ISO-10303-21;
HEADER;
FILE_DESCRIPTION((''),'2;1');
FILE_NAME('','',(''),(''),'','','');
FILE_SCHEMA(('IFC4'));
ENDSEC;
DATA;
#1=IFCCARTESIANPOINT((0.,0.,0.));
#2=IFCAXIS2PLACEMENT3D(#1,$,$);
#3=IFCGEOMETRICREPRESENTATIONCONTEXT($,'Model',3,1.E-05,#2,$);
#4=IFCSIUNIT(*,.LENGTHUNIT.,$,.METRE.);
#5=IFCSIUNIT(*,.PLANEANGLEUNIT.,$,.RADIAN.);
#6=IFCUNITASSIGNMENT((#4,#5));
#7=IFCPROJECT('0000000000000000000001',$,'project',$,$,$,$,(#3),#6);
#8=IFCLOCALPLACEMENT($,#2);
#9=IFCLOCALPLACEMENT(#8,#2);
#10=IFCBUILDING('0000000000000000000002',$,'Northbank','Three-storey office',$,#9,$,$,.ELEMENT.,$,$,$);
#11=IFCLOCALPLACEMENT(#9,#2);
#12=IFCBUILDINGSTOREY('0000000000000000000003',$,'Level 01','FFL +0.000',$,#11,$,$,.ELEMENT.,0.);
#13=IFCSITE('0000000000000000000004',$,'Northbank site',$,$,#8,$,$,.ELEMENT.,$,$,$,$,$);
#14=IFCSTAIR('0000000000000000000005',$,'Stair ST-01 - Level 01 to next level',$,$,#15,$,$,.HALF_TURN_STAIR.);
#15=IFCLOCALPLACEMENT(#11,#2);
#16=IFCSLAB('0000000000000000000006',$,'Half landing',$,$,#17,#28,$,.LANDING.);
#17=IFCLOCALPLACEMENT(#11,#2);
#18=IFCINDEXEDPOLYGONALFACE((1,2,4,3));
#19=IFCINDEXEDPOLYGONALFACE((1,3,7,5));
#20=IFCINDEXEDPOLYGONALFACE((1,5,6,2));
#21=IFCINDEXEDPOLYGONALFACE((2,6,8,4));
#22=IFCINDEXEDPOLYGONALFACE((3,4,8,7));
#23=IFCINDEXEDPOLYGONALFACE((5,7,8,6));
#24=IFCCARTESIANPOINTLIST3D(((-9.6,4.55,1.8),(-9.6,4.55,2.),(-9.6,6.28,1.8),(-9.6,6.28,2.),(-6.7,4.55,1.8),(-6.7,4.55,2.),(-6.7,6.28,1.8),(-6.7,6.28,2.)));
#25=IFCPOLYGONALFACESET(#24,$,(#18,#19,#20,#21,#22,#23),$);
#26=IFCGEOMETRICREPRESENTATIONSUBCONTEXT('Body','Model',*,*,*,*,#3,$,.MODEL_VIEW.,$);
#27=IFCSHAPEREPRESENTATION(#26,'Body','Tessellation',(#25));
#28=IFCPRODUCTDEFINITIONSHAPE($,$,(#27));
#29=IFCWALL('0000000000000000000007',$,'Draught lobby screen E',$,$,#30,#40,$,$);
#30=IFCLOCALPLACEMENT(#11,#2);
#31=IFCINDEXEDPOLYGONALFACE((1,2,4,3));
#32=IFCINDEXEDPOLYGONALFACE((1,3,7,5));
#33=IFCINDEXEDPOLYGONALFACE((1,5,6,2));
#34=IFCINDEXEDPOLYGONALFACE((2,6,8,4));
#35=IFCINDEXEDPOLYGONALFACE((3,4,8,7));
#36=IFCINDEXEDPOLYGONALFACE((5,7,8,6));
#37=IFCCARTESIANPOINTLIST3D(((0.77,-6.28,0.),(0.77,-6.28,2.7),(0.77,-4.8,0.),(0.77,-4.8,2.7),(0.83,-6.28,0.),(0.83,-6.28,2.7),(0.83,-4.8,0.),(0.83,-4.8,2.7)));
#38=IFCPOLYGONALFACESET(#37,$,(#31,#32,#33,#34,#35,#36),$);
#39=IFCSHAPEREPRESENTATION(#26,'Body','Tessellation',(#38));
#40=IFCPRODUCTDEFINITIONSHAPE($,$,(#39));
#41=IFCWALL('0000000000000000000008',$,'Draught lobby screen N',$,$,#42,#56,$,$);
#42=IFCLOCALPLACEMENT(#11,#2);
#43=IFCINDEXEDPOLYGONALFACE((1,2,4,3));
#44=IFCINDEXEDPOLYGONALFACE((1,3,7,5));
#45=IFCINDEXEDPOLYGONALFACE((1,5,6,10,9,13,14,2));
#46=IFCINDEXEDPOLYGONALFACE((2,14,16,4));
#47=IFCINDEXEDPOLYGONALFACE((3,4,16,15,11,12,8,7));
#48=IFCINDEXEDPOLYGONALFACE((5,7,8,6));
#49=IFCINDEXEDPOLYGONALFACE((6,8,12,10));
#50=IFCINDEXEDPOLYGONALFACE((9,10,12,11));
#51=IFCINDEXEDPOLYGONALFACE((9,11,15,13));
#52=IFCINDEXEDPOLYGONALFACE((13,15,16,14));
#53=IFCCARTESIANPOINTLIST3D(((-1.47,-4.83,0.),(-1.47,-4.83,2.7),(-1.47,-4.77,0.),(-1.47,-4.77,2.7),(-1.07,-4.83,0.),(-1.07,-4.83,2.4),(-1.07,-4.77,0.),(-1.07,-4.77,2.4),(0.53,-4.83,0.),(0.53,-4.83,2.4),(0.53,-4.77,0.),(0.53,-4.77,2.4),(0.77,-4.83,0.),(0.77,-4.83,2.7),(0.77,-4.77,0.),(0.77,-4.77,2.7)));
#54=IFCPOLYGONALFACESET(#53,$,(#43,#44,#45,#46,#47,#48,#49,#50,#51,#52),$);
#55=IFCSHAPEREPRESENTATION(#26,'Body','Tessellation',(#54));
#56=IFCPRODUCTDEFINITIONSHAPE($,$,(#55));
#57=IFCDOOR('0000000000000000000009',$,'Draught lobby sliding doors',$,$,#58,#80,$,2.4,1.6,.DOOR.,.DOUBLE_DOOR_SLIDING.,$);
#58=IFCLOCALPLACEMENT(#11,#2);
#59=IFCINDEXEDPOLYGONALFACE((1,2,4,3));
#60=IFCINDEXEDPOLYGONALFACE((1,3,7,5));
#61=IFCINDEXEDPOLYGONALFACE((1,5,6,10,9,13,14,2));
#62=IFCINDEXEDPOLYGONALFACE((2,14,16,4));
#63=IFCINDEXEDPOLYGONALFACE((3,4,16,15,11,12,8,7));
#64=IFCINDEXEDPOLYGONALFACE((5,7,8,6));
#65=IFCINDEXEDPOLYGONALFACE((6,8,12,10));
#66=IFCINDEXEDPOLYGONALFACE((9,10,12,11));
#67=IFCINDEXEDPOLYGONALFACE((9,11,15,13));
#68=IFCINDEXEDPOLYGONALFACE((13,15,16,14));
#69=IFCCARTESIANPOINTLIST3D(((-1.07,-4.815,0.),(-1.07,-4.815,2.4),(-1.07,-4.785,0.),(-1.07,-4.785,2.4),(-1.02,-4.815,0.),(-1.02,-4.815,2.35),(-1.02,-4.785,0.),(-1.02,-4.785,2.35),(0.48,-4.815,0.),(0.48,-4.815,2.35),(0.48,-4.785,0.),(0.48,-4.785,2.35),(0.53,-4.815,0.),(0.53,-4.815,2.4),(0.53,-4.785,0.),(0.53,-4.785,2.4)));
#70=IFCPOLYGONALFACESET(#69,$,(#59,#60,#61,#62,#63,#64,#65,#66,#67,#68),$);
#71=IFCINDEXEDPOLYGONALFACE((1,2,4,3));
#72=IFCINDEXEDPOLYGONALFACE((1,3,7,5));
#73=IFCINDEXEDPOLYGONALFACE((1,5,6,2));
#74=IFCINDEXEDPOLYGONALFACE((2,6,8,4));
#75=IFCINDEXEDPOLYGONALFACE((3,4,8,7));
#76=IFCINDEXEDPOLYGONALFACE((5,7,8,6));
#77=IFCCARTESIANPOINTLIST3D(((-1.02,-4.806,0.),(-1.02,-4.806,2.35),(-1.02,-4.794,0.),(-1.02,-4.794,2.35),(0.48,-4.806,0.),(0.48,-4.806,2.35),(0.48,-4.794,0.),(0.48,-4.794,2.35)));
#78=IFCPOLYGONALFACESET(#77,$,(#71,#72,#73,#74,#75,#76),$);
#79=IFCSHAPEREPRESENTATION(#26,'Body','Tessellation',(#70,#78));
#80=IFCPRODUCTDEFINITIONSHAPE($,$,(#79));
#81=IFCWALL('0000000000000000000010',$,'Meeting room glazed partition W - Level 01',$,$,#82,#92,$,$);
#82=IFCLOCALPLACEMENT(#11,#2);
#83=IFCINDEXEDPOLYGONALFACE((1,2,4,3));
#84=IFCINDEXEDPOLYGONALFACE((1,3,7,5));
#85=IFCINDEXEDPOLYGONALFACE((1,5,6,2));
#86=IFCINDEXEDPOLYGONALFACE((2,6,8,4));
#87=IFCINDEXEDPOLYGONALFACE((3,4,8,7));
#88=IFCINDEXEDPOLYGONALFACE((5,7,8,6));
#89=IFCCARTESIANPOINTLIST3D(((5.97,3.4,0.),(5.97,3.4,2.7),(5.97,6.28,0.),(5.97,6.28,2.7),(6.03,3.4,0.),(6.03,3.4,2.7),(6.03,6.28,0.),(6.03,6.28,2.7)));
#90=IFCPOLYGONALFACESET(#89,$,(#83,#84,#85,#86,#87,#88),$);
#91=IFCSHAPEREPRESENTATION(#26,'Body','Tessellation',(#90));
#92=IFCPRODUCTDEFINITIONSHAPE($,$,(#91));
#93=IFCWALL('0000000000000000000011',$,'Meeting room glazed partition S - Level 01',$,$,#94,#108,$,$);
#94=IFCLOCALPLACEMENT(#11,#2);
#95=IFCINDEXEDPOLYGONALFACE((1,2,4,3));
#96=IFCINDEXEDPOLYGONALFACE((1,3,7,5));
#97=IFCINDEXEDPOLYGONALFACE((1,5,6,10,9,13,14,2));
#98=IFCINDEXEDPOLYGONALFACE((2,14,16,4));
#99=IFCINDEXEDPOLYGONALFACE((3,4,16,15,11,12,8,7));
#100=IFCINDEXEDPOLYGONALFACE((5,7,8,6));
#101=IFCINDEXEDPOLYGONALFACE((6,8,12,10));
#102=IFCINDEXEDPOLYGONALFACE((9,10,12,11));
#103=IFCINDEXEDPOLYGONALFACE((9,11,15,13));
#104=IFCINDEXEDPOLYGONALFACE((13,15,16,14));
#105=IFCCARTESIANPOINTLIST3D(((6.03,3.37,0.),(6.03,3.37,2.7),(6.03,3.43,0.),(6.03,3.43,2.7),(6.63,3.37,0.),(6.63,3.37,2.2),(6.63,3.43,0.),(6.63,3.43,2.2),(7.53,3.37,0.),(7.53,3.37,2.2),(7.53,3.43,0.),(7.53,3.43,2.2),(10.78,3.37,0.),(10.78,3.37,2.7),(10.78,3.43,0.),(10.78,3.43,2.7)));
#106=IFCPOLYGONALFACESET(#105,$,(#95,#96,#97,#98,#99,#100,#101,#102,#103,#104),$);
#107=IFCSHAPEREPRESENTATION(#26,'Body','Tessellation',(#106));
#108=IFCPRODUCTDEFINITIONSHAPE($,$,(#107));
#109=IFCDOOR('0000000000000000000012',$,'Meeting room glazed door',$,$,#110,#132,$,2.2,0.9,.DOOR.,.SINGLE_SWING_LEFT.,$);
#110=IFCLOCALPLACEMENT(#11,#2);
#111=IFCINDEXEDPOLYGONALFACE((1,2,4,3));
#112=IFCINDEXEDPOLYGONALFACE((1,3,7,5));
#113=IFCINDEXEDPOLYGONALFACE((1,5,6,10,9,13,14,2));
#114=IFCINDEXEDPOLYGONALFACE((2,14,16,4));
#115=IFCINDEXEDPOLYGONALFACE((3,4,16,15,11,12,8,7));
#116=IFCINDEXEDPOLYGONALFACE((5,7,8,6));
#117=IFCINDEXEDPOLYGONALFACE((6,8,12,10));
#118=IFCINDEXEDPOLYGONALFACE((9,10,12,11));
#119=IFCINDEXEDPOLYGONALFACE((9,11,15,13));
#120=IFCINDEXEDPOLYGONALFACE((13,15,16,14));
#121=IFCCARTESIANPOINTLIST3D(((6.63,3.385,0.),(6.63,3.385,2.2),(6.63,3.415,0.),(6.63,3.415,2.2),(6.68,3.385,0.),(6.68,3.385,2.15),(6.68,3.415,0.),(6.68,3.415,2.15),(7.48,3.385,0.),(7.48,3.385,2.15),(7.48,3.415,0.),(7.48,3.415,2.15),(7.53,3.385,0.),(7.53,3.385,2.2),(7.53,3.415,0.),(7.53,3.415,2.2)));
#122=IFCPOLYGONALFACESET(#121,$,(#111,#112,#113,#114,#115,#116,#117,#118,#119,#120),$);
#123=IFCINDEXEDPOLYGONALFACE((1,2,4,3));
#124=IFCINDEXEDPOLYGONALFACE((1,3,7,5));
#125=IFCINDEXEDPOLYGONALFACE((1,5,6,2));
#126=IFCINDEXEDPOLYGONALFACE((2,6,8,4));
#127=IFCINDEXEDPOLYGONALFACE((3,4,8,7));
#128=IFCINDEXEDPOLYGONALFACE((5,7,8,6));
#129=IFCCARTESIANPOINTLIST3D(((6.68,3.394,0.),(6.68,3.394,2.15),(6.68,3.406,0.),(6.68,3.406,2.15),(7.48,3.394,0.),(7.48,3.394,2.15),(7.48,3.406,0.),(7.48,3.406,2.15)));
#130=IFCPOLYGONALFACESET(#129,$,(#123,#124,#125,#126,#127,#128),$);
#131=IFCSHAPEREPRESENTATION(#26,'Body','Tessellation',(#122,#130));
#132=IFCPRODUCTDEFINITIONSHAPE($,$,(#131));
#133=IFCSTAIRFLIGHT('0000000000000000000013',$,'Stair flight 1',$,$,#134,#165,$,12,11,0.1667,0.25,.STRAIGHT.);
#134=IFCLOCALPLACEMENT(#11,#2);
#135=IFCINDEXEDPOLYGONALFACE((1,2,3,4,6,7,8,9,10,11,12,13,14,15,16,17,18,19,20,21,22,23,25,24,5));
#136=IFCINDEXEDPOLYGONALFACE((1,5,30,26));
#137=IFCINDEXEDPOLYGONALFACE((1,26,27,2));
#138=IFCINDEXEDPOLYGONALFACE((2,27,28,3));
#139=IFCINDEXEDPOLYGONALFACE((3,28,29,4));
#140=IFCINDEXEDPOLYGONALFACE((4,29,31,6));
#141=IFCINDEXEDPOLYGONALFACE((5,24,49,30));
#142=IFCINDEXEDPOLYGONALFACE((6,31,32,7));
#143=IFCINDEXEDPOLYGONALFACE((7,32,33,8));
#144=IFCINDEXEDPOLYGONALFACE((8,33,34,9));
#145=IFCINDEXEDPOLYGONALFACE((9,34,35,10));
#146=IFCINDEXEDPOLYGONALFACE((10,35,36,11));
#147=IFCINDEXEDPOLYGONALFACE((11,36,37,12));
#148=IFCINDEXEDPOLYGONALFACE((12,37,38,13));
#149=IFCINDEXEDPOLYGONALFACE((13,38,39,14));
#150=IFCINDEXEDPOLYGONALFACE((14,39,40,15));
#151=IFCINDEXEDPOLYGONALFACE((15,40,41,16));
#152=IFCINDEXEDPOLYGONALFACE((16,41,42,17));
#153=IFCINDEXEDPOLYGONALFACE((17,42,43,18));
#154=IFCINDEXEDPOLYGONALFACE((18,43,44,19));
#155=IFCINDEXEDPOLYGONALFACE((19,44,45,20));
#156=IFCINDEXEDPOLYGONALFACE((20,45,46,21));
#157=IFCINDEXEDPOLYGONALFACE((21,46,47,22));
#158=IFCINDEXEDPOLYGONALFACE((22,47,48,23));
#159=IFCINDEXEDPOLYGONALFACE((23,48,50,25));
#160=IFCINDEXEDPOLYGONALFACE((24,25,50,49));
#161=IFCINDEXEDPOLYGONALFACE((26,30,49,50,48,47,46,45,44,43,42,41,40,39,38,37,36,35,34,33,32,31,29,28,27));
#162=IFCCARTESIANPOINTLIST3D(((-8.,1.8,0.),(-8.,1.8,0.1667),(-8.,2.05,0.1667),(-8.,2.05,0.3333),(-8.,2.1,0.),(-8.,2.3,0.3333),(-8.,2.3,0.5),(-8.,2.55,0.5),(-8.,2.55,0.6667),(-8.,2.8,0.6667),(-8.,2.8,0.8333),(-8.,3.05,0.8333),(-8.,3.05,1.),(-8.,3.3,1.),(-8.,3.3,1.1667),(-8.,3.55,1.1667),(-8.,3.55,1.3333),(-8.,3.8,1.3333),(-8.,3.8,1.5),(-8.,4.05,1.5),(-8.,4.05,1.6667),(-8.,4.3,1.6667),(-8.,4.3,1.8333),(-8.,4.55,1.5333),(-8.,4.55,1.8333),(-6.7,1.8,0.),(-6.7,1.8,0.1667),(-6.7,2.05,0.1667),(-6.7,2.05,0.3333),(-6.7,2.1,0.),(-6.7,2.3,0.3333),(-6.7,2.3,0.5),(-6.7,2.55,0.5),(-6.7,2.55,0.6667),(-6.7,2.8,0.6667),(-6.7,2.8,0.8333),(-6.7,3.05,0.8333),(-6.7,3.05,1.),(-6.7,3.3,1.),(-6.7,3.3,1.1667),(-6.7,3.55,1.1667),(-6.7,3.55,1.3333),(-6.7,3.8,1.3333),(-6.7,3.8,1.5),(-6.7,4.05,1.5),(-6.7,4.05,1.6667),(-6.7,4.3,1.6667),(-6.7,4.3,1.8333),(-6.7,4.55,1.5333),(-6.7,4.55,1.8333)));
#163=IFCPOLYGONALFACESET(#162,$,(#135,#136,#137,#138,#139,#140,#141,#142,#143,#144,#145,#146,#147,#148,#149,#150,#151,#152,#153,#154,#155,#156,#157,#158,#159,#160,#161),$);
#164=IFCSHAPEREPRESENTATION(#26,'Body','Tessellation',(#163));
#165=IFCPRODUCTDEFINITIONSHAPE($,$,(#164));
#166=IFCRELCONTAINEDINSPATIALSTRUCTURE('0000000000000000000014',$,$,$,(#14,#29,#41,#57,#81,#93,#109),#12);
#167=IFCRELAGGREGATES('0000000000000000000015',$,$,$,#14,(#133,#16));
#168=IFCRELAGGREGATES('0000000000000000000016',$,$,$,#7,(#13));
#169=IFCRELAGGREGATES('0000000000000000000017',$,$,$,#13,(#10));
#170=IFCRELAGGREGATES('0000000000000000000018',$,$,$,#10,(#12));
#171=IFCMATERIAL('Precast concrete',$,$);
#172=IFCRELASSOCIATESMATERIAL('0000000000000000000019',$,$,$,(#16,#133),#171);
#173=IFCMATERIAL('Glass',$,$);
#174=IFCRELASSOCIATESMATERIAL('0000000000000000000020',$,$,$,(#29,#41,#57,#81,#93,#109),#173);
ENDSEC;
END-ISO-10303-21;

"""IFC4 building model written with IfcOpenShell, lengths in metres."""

from ifc_helpers import new_model, si_unit, frame, origin, place, context, subcontext, project, spatial, polyline, rectangle, outline, extrude, material, element, fill, aggregate, save


model = new_model("IFC4")

# Units and contexts
model_context = context("Model", 3, precision=1e-05, world=origin())
body_context = subcontext(model_context, "Body", "Model", "MODEL_VIEW")
ifc_project = project(units=[si_unit("LENGTHUNIT", "METRE"), si_unit("PLANEANGLEUNIT", "RADIAN")], contexts=[model_context])

# Site, building, storey
site_placement = place(None, origin())
site = spatial("IfcSite", under=ifc_project, at=site_placement, Name="Northbank site", CompositionType="ELEMENT")
building_placement = place(site_placement, origin())
building = spatial("IfcBuilding", under=site, at=building_placement, Name="Northbank", Description="Three-storey office", CompositionType="ELEMENT")
storey_placement = place(building_placement, origin())
storey = spatial("IfcBuildingStorey", under=building, at=storey_placement, Name="Level 01", Description="FFL +0.000", CompositionType="ELEMENT", Elevation=0.0)

# Stair, slab
stair_placement = place(storey_placement, origin())
stair = element("IfcStair", 1, at=stair_placement, inside=storey, Name="Stair ST-01 - Level 01 to next level", PredefinedType="HALF_TURN_STAIR")
ifc_material_1 = material(Name="Precast concrete")
slab_placement = place(storey_placement, origin())
slab = element("IfcSlab", 2, at=slab_placement, material=ifc_material_1, Name="Half landing", PredefinedType="LANDING", context=body_context, shape_type="SweptSolid", body=[
    extrude(rectangle(XDim=2.9, YDim=1.73), frame((-8.15, 5.415, 1.8)), (0.0, 0.0, 1.0), 0.2),
])

# Wall
ifc_material_2 = material(Name="Glass")
wall_1_placement = place(storey_placement, origin())
element("IfcWall", 3, at=wall_1_placement, inside=storey, material=ifc_material_2, Name="Draught lobby screen E", context=body_context, shape_type="SweptSolid", body=[
    extrude(outline(polyline([(0.0, 0.0), (1.48, 0.0), (1.48, 2.7), (0.0, 2.7), (0.0, 0.0)])), frame((0.77, -6.28, 0.0), z_axis=(1.0, 0.0, 0.0), x_axis=(0.0, 1.0, 0.0)), (0.0, 0.0, 1.0), 0.06),
])

# Wall, opening, door
wall_2_placement = place(storey_placement, origin())
wall_2 = element("IfcWall", 4, at=wall_2_placement, inside=storey, material=ifc_material_2, Name="Draught lobby screen N", context=body_context, shape_type="SweptSolid", body=[
    extrude(outline(polyline([(0.0, 0.0), (0.4, 0.0), (0.4, 2.4), (2.0, 2.4), (2.0, 0.0), (2.24, 0.0), (2.24, 2.7), (0.0, 2.7), (0.0, 0.0)])), frame((-1.47, -4.77, 0.0), z_axis=(0.0, -1.0, 0.0), x_axis=(1.0, 0.0, 0.0)), (0.0, 0.0, 1.0), 0.06),
])
opening_1_placement = place(storey_placement, origin())
opening_1 = element("IfcOpeningElement", 5, at=opening_1_placement, cuts=wall_2, PredefinedType="OPENING", context=body_context, shape_type="SweptSolid", body=[
    extrude(outline(polyline([(0.0, 0.0), (1.6, 0.0), (1.6, 2.4), (0.0, 2.4), (0.0, 0.0)])), frame((-1.07, -4.72, 0.0), z_axis=(0.0, -1.0, 0.0), x_axis=(1.0, 0.0, 0.0)), (0.0, 0.0, 1.0), 0.16),
])
door_1_placement = place(storey_placement, origin())
door_1 = element("IfcDoor", 6, at=door_1_placement, inside=storey, material=ifc_material_2, Name="Draught lobby sliding doors", OperationType="DOUBLE_DOOR_SLIDING", OverallHeight=2.4, OverallWidth=1.6, PredefinedType="DOOR", context=body_context, shape_type="SweptSolid", body=[
    extrude(outline(polyline([(0.0, 0.0), (0.05, 0.0), (0.05, 2.35), (1.55, 2.35), (1.55, 0.0), (1.6, 0.0), (1.6, 2.4), (0.0, 2.4), (0.0, 0.0)])), frame((-1.07, -4.785, 0.0), z_axis=(0.0, -1.0, 0.0), x_axis=(1.0, 0.0, 0.0)), (0.0, 0.0, 1.0), 0.03),
    extrude(outline(polyline([(0.0, 0.0), (1.5, 0.0), (1.5, 2.35), (0.0, 2.35), (0.0, 0.0)])), frame((-1.02, -4.794, 0.0), z_axis=(0.0, -1.0, 0.0), x_axis=(1.0, 0.0, 0.0)), (0.0, 0.0, 1.0), 0.012),
])
fill(opening_1, door_1)

# Wall
wall_3_placement = place(storey_placement, origin())
element("IfcWall", 7, at=wall_3_placement, inside=storey, material=ifc_material_2, Name="Meeting room glazed partition W - Level 01", context=body_context, shape_type="SweptSolid", body=[
    extrude(outline(polyline([(0.0, 0.0), (2.88, 0.0), (2.88, 2.7), (0.0, 2.7), (0.0, 0.0)])), frame((5.97, 3.4, 0.0), z_axis=(1.0, 0.0, 0.0), x_axis=(0.0, 1.0, 0.0)), (0.0, 0.0, 1.0), 0.06),
])

# Wall, opening, door
wall_4_placement = place(storey_placement, origin())
wall_4 = element("IfcWall", 8, at=wall_4_placement, inside=storey, material=ifc_material_2, Name="Meeting room glazed partition S - Level 01", context=body_context, shape_type="SweptSolid", body=[
    extrude(outline(polyline([(0.0, 0.0), (0.6, 0.0), (0.6, 2.2), (1.5, 2.2), (1.5, 0.0), (4.75, 0.0), (4.75, 2.7), (0.0, 2.7), (0.0, 0.0)])), frame((6.03, 3.43, 0.0), z_axis=(0.0, -1.0, 0.0), x_axis=(1.0, 0.0, 0.0)), (0.0, 0.0, 1.0), 0.06),
])
opening_2_placement = place(storey_placement, origin())
opening_2 = element("IfcOpeningElement", 9, at=opening_2_placement, cuts=wall_4, PredefinedType="OPENING", context=body_context, shape_type="SweptSolid", body=[
    extrude(outline(polyline([(0.0, 0.0), (0.9, 0.0), (0.9, 2.2), (0.0, 2.2), (0.0, 0.0)])), frame((6.63, 3.48, 0.0), z_axis=(0.0, -1.0, 0.0), x_axis=(1.0, 0.0, 0.0)), (0.0, 0.0, 1.0), 0.16),
])
door_2_placement = place(storey_placement, origin())
door_2 = element("IfcDoor", 10, at=door_2_placement, inside=storey, material=ifc_material_2, Name="Meeting room glazed door", OperationType="SINGLE_SWING_LEFT", OverallHeight=2.2, OverallWidth=0.9, PredefinedType="DOOR", context=body_context, shape_type="SweptSolid", body=[
    extrude(outline(polyline([(0.0, 0.0), (0.05, 0.0), (0.05, 2.15), (0.85, 2.15), (0.85, 0.0), (0.9, 0.0), (0.9, 2.2), (0.0, 2.2), (0.0, 0.0)])), frame((6.63, 3.415, 0.0), z_axis=(0.0, -1.0, 0.0), x_axis=(1.0, 0.0, 0.0)), (0.0, 0.0, 1.0), 0.03),
    extrude(outline(polyline([(0.0, 0.0), (0.8, 0.0), (0.8, 2.15), (0.0, 2.15), (0.0, 0.0)])), frame((6.68, 3.406, 0.0), z_axis=(0.0, -1.0, 0.0), x_axis=(1.0, 0.0, 0.0)), (0.0, 0.0, 1.0), 0.012),
])
fill(opening_2, door_2)

# Stair flight
stair_flight_1_placement = place(storey_placement, origin())
stair_flight_1 = element("IfcStairFlight", 11, at=stair_flight_1_placement, material=ifc_material_1, Name="Stair flight 1", NumberOfRisers=12, NumberOfTreads=11, PredefinedType="STRAIGHT", RiserHeight=0.1667, TreadLength=0.25, context=body_context, shape_type="SweptSolid", body=[
    extrude(outline(polyline([(1.8, 0.0), (1.8, 0.1667), (2.05, 0.1667), (2.05, 0.3333), (2.3, 0.3333), (2.3, 0.5), (2.55, 0.5), (2.55, 0.6667), (2.8, 0.6667), (2.8, 0.8333), (3.05, 0.8333), (3.05, 1.0), (3.3, 1.0), (3.3, 1.1667), (3.55, 1.1667), (3.55, 1.3333), (3.8, 1.3333), (3.8, 1.5), (4.05, 1.5), (4.05, 1.6667), (4.3, 1.6667), (4.3, 1.8333), (4.55, 1.8333), (4.55, 1.5333), (2.1, 0.0), (1.8, 0.0)])), frame((-8.0, 0.0, 0.0), z_axis=(1.0, 0.0, 0.0), x_axis=(0.0, 1.0, 0.0)), (0.0, 0.0, 1.0), 1.3),
])
aggregate(stair, [stair_flight_1, slab])

save(model, "model.ifc")
